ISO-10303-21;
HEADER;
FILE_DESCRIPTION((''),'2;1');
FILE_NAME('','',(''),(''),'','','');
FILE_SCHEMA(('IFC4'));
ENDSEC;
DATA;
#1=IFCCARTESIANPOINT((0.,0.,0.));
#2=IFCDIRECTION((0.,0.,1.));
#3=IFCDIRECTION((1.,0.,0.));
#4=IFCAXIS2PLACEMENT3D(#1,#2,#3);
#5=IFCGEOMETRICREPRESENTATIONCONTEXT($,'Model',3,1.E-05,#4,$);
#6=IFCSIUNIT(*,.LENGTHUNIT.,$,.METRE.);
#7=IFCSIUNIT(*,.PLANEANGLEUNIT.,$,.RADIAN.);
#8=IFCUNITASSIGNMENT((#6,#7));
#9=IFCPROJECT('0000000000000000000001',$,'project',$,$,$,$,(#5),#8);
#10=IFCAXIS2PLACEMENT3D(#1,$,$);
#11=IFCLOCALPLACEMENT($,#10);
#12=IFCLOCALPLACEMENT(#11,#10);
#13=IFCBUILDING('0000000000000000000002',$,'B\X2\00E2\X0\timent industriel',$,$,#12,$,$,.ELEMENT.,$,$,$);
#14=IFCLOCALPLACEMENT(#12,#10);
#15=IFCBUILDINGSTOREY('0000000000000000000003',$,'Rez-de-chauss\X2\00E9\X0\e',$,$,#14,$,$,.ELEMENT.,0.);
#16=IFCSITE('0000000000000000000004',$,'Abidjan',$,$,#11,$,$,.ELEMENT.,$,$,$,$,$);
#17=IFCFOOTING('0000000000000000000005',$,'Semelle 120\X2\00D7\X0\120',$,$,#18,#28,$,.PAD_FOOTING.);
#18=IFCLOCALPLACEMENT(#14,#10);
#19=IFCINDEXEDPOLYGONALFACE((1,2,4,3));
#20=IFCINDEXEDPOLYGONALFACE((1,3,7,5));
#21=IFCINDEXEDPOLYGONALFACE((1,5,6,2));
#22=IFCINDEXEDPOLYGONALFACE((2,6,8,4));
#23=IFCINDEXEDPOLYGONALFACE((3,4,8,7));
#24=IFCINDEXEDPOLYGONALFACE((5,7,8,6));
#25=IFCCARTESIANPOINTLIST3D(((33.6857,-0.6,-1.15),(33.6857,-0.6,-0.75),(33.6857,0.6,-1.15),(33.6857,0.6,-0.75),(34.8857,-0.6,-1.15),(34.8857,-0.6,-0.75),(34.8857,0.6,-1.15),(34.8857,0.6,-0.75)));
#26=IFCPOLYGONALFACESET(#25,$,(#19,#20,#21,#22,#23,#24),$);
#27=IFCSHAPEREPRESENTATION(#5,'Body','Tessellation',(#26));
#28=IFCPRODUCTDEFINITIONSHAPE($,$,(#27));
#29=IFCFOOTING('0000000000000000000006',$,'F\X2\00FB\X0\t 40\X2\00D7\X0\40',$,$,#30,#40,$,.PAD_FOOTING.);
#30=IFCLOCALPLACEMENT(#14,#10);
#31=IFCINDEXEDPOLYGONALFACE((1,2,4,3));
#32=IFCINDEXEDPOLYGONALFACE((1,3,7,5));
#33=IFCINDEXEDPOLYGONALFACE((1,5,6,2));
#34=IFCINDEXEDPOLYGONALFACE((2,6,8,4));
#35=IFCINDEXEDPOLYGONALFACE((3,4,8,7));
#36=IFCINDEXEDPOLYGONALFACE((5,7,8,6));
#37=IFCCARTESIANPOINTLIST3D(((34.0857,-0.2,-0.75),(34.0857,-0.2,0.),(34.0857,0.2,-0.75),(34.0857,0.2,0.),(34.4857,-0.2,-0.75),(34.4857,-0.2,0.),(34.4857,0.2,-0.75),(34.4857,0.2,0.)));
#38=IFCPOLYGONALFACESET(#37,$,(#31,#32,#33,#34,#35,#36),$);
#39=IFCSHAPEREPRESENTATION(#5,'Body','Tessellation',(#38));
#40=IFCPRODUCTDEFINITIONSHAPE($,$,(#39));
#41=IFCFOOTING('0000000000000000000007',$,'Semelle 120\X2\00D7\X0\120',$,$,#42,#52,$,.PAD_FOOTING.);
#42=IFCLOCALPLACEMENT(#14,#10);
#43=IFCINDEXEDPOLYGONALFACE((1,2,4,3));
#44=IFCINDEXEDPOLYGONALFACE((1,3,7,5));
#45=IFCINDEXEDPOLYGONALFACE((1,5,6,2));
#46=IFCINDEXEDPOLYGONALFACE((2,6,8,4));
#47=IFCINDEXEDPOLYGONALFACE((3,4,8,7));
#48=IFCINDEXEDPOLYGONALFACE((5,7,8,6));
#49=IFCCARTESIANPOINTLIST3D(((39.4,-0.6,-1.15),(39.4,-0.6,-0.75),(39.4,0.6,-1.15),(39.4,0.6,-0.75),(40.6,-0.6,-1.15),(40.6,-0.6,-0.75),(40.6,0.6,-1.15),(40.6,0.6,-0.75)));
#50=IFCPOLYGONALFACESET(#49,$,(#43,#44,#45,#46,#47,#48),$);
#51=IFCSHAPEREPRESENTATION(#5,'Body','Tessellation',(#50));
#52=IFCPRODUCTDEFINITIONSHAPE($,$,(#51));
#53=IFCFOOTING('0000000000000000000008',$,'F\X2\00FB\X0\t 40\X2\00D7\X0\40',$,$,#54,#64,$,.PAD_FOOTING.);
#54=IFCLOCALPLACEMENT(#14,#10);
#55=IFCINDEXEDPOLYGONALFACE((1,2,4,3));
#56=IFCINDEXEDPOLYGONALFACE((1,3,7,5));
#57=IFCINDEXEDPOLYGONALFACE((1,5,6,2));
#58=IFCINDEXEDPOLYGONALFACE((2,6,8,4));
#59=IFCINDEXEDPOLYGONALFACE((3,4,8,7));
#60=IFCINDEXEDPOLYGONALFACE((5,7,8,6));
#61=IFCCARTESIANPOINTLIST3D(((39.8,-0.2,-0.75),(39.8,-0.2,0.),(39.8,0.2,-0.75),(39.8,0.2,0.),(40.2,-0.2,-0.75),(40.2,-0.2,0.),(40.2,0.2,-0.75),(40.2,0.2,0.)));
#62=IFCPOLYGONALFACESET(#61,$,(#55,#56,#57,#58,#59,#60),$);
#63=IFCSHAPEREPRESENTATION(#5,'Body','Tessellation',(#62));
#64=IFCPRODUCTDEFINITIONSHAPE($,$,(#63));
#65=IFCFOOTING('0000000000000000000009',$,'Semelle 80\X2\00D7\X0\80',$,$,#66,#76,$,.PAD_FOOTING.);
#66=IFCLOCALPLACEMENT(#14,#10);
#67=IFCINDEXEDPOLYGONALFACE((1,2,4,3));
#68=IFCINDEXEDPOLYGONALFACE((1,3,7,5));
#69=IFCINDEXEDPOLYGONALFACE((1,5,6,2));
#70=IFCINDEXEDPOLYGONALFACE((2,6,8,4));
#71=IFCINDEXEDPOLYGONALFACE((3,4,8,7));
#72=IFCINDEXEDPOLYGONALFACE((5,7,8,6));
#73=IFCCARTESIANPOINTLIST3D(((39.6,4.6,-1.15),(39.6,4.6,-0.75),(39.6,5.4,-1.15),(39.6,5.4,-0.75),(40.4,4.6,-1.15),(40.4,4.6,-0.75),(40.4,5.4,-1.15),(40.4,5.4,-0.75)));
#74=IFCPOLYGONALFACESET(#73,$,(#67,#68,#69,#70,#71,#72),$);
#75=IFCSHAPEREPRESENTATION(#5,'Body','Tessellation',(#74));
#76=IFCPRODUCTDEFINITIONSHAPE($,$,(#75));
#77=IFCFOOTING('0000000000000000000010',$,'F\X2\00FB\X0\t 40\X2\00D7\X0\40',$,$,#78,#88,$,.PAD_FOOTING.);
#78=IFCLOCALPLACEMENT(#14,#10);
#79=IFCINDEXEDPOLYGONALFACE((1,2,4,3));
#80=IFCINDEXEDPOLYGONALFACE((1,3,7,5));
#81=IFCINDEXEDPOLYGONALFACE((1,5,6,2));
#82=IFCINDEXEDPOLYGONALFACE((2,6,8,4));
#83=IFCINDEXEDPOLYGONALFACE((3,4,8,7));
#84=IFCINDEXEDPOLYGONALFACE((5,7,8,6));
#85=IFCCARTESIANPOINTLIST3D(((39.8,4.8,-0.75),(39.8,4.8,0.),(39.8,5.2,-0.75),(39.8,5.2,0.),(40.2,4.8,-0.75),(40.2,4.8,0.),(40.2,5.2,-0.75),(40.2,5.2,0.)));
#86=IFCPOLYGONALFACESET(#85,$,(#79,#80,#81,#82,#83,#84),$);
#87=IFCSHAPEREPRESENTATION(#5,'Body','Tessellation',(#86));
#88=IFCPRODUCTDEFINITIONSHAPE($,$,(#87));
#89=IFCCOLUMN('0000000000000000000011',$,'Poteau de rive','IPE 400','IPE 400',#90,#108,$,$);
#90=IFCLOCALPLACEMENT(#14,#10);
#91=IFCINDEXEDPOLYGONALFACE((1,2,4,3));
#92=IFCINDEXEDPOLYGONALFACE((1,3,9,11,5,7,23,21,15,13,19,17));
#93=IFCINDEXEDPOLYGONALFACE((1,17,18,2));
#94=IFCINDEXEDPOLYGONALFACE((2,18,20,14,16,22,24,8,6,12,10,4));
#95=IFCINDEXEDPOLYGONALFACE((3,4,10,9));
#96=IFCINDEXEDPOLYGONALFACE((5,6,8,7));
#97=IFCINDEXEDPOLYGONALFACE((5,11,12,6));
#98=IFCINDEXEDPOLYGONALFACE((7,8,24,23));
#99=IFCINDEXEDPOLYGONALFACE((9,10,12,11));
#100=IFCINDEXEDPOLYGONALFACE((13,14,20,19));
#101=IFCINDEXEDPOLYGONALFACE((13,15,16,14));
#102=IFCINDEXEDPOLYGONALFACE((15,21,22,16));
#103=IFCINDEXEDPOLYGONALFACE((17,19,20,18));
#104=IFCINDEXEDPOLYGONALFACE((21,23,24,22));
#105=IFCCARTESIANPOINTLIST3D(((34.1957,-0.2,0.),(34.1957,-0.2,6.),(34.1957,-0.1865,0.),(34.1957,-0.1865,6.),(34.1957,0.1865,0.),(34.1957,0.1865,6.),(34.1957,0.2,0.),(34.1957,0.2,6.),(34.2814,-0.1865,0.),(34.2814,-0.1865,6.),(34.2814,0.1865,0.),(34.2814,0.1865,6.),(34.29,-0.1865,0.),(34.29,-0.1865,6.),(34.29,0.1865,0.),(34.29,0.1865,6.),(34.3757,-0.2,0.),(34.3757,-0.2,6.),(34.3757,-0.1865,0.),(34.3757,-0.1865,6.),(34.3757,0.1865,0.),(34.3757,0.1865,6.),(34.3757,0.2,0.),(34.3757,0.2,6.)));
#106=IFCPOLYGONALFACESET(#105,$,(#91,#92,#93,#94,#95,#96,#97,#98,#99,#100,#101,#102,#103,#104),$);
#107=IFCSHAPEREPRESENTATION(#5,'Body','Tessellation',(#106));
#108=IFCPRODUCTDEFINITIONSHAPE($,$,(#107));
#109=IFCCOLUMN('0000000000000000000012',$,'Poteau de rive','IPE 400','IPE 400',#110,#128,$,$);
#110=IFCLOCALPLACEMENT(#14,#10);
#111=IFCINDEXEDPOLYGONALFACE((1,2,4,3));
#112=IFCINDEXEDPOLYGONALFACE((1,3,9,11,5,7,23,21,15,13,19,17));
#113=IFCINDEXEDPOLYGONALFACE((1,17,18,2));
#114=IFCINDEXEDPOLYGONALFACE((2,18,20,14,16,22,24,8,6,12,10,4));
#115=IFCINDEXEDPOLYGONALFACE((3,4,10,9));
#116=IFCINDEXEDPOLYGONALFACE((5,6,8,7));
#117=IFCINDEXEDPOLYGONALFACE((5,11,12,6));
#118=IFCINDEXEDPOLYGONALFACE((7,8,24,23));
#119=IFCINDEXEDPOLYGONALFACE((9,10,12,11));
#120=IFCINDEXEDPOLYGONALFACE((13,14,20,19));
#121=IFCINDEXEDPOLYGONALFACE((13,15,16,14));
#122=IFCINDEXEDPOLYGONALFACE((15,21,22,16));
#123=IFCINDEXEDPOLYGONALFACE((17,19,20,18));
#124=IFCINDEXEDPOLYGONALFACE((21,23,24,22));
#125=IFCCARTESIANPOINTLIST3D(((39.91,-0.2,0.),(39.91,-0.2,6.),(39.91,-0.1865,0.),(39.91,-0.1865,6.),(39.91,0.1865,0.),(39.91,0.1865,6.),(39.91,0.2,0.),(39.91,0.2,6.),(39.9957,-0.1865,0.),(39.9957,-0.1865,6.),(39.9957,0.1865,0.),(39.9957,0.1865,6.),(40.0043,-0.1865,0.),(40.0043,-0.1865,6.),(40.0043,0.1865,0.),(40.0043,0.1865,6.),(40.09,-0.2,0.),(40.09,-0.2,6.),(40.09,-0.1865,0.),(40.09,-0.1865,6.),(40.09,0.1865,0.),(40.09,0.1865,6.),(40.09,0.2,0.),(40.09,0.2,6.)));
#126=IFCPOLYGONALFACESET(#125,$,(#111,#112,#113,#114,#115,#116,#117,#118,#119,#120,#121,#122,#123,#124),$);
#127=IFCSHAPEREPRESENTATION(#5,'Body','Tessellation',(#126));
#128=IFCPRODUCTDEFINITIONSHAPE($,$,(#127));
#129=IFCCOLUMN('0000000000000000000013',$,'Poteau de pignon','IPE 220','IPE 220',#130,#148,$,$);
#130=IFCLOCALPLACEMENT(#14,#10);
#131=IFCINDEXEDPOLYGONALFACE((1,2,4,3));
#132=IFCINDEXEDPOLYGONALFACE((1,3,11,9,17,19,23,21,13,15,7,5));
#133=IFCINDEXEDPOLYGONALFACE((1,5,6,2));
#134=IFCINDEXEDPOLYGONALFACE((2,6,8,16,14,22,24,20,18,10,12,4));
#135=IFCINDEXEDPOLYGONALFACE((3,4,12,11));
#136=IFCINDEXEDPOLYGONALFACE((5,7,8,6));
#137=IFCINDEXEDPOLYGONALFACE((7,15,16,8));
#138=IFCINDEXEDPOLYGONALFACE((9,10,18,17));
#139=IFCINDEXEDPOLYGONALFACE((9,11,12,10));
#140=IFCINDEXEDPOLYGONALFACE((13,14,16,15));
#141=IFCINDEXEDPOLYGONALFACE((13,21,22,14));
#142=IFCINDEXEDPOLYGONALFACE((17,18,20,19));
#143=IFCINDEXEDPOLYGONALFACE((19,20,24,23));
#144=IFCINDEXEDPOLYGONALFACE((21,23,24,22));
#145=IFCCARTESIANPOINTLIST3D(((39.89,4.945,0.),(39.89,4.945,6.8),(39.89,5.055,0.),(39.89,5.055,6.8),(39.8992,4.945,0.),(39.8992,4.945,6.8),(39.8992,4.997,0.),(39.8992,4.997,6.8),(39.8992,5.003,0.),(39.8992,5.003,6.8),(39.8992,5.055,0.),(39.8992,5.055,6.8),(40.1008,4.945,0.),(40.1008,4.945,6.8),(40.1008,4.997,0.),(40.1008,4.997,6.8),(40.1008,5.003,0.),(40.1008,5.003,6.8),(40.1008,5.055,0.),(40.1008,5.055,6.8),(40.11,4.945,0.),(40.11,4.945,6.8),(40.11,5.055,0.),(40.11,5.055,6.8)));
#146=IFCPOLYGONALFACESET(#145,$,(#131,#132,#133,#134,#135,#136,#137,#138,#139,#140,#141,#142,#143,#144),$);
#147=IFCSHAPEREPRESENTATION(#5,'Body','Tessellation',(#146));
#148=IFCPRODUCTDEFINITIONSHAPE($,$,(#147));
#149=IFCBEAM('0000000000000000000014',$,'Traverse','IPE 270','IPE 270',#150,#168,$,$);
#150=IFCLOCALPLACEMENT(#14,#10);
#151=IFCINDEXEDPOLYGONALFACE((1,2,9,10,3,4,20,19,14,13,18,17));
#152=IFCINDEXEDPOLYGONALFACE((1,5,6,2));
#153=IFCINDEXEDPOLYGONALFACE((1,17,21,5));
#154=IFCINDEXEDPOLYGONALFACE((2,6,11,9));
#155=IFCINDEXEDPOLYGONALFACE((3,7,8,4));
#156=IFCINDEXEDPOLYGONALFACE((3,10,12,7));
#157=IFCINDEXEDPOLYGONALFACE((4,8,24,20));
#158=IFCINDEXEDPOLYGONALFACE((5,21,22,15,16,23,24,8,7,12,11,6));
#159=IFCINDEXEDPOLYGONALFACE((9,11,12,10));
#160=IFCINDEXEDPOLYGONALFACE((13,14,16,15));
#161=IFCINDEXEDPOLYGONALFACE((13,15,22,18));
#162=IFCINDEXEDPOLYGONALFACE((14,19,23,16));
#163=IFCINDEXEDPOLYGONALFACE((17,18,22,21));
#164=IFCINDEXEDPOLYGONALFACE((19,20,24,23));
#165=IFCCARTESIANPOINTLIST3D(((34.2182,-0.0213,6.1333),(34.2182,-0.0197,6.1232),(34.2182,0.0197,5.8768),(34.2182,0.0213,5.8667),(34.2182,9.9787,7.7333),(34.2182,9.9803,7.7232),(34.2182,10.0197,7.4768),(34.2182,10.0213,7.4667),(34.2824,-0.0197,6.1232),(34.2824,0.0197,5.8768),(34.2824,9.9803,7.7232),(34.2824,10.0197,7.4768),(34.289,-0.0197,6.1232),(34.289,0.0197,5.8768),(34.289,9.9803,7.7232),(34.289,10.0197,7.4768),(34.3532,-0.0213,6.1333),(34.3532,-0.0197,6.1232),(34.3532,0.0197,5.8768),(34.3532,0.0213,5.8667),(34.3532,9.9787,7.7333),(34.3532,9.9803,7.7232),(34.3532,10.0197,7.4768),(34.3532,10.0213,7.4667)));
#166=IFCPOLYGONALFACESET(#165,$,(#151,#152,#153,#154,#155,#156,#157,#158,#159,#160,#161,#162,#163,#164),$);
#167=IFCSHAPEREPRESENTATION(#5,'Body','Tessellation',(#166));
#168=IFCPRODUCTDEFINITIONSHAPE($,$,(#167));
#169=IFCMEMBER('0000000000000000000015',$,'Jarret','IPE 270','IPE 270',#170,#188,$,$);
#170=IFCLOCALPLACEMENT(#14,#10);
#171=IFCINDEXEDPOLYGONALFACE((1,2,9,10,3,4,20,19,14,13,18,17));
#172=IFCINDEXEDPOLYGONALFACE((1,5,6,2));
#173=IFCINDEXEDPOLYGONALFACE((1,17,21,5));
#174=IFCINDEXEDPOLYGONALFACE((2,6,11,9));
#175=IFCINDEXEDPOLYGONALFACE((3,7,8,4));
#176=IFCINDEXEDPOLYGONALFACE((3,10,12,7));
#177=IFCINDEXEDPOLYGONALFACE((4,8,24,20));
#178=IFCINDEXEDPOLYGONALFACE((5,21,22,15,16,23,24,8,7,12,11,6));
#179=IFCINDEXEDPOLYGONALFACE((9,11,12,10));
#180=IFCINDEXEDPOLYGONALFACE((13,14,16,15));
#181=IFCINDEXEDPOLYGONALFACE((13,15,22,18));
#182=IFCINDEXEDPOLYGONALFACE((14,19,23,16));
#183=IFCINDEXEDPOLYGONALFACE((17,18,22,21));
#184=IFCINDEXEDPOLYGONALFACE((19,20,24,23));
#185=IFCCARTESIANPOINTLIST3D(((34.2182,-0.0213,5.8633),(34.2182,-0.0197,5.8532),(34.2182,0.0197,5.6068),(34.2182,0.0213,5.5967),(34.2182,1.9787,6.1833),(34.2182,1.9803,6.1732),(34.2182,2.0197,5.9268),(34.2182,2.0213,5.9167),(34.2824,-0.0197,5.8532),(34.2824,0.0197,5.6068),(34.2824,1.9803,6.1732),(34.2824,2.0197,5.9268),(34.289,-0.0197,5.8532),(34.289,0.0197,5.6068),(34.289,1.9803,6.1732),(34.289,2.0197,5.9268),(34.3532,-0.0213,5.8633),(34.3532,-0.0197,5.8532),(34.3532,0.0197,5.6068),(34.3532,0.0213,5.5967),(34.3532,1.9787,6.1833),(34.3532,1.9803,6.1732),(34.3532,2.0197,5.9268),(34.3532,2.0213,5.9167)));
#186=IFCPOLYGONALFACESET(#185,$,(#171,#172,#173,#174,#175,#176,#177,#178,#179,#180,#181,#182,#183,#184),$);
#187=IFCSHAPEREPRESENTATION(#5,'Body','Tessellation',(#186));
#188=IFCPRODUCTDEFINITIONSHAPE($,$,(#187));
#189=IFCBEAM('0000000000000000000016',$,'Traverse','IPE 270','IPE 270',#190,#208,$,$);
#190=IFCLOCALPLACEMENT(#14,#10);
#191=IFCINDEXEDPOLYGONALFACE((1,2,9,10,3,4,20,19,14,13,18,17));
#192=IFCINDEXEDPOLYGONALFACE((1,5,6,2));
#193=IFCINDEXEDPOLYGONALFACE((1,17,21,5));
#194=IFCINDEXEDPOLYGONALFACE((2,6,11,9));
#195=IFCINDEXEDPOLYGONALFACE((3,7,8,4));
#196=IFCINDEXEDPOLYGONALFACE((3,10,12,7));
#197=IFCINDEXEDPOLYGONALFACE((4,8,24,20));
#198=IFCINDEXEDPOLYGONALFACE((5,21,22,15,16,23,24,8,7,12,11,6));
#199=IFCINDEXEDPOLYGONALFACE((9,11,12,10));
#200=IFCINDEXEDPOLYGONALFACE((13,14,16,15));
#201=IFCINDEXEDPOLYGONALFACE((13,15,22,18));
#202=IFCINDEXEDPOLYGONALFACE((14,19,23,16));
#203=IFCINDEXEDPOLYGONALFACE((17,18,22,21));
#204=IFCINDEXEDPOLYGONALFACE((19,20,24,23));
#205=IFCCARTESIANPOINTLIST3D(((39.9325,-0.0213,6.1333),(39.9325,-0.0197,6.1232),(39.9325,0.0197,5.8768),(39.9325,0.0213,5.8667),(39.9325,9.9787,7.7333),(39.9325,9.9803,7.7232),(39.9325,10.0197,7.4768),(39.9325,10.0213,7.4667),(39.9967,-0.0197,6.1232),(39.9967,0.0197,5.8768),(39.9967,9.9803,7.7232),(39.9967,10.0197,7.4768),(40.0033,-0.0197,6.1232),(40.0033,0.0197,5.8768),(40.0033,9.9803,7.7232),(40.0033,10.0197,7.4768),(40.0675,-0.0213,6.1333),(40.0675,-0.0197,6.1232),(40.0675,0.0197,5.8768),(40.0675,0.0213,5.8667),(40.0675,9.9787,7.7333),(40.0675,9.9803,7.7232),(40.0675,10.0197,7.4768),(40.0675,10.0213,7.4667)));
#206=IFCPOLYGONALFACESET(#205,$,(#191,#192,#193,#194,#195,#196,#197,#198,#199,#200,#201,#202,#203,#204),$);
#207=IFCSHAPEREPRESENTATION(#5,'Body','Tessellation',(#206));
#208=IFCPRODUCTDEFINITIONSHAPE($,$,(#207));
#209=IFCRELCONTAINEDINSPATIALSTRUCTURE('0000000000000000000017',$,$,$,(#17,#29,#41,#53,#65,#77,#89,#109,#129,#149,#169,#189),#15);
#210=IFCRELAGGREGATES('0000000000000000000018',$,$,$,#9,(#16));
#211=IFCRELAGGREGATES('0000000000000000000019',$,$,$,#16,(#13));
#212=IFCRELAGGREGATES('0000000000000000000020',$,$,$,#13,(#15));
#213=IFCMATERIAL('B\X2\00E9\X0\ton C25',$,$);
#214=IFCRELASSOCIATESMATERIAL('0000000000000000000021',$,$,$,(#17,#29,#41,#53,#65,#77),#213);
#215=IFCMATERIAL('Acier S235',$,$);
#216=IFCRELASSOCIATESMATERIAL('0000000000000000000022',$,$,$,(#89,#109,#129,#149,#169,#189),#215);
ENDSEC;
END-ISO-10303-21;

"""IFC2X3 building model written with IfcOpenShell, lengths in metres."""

from ifc_helpers import new_model, si_unit, frame, origin, origin_with_axes, origin_2d, place, context, project, spatial, rectangle, i_section, extrude, material, element, save


model = new_model("IFC2X3")

# Units and contexts
model_context = context("Model", 3, precision=1e-05, world=origin_with_axes())
ifc_project = project(units=[si_unit("LENGTHUNIT", "METRE"), si_unit("PLANEANGLEUNIT", "RADIAN")], contexts=[model_context])

# Site, building, storey
site_placement = place(None, origin())
site = spatial("IfcSite", under=ifc_project, at=site_placement, Name="Abidjan", CompositionType="ELEMENT")
building_placement = place(site_placement, origin())
building = spatial("IfcBuilding", under=site, at=building_placement, Name="Bâtiment industriel", CompositionType="ELEMENT")
storey_placement = place(building_placement, origin())
storey = spatial("IfcBuildingStorey", under=building, at=storey_placement, Name="Rez-de-chaussée", CompositionType="ELEMENT", Elevation=0.0)

# Footings
ifc_material_1 = material(Name="Béton C25")
footing_1_placement = place(storey_placement, frame((34.2857, 0.0, -1.15), z_axis=(0.0, 0.0, 1.0), x_axis=(1.0, 0.0, 0.0)))
element("IfcFooting", 1, at=footing_1_placement, inside=storey, material=ifc_material_1, Name="Semelle 120×120", PredefinedType="PAD_FOOTING", context=model_context, shape_type="SweptSolid", body=[
    extrude(rectangle(XDim=1.2, YDim=1.2, at=origin_2d()), origin(), (0.0, 0.0, 1.0), 0.4),
])
footing_2_placement = place(storey_placement, frame((34.2857, 0.0, -0.75), z_axis=(0.0, 0.0, 1.0), x_axis=(1.0, 0.0, 0.0)))
element("IfcFooting", 2, at=footing_2_placement, inside=storey, material=ifc_material_1, Name="Fût 40×40", PredefinedType="PAD_FOOTING", context=model_context, shape_type="SweptSolid", body=[
    extrude(rectangle(XDim=0.4, YDim=0.4, at=origin_2d()), origin(), (0.0, 0.0, 1.0), 0.75),
])
footing_3_placement = place(storey_placement, frame((40.0, 0.0, -1.15), z_axis=(0.0, 0.0, 1.0), x_axis=(1.0, 0.0, 0.0)))
element("IfcFooting", 3, at=footing_3_placement, inside=storey, material=ifc_material_1, Name="Semelle 120×120", PredefinedType="PAD_FOOTING", context=model_context, shape_type="SweptSolid", body=[
    extrude(rectangle(XDim=1.2, YDim=1.2, at=origin_2d()), origin(), (0.0, 0.0, 1.0), 0.4),
])
footing_4_placement = place(storey_placement, frame((40.0, 0.0, -0.75), z_axis=(0.0, 0.0, 1.0), x_axis=(1.0, 0.0, 0.0)))
element("IfcFooting", 4, at=footing_4_placement, inside=storey, material=ifc_material_1, Name="Fût 40×40", PredefinedType="PAD_FOOTING", context=model_context, shape_type="SweptSolid", body=[
    extrude(rectangle(XDim=0.4, YDim=0.4, at=origin_2d()), origin(), (0.0, 0.0, 1.0), 0.75),
])
footing_5_placement = place(storey_placement, frame((40.0, 5.0, -1.15), z_axis=(0.0, 0.0, 1.0), x_axis=(1.0, 0.0, 0.0)))
element("IfcFooting", 5, at=footing_5_placement, inside=storey, material=ifc_material_1, Name="Semelle 80×80", PredefinedType="PAD_FOOTING", context=model_context, shape_type="SweptSolid", body=[
    extrude(rectangle(XDim=0.8, YDim=0.8, at=origin_2d()), origin(), (0.0, 0.0, 1.0), 0.4),
])
footing_6_placement = place(storey_placement, frame((40.0, 5.0, -0.75), z_axis=(0.0, 0.0, 1.0), x_axis=(1.0, 0.0, 0.0)))
element("IfcFooting", 6, at=footing_6_placement, inside=storey, material=ifc_material_1, Name="Fût 40×40", PredefinedType="PAD_FOOTING", context=model_context, shape_type="SweptSolid", body=[
    extrude(rectangle(XDim=0.4, YDim=0.4, at=origin_2d()), origin(), (0.0, 0.0, 1.0), 0.75),
])

# Columns
ifc_material_2 = material(Name="Acier S235")
for number, where, z_axis, x_axis, name in (
    (7, (34.2857, 0.0, 0.0), (0.0, 0.0, 1.0), (1.0, 0.0, 0.0), "Poteau de rive"),
    (8, (40.0, 0.0, 0.0), (0.0, 0.0, 1.0), (1.0, 0.0, 0.0), "Poteau de rive"),
):
    element("IfcColumn", number, at=place(storey_placement, frame(where, z_axis=z_axis, x_axis=x_axis)), inside=storey, material=ifc_material_2, Name=name, Description="IPE 400", ObjectType="IPE 400", context=model_context, shape_type="SweptSolid", body=[
        extrude(i_section(OverallWidth=0.18, OverallDepth=0.4, WebThickness=0.0086, FlangeThickness=0.0135, at=origin_2d()), origin(), (0.0, 0.0, 1.0), 6.0),
    ])
column_placement = place(storey_placement, frame((40.0, 5.0, 0.0), z_axis=(0.0, 0.0, 1.0), x_axis=(0.0, 1.0, 0.0)))
element("IfcColumn", 9, at=column_placement, inside=storey, material=ifc_material_2, Name="Poteau de pignon", Description="IPE 220", ObjectType="IPE 220", context=model_context, shape_type="SweptSolid", body=[
    extrude(i_section(OverallWidth=0.11, OverallDepth=0.22, WebThickness=0.0059, FlangeThickness=0.0092, at=origin_2d()), origin(), (0.0, 0.0, 1.0), 6.8),
])

# Beam
beam_1_placement = place(storey_placement, frame((34.2857, 0.0, 6.0), z_axis=(0.0, 0.98744, 0.15799), x_axis=(1.0, 0.0, 0.0)))
element("IfcBeam", 10, at=beam_1_placement, inside=storey, material=ifc_material_2, Name="Traverse", Description="IPE 270", ObjectType="IPE 270", context=model_context, shape_type="SweptSolid", body=[
    extrude(i_section(OverallWidth=0.135, OverallDepth=0.27, WebThickness=0.0066, FlangeThickness=0.0102, at=origin_2d()), origin(), (0.0, 0.0, 1.0), 10.1272),
])

# Member
member_1_placement = place(storey_placement, frame((34.2857, 0.0, 5.73), z_axis=(0.0, 0.98744, 0.15799), x_axis=(1.0, 0.0, 0.0)))
element("IfcMember", 11, at=member_1_placement, inside=storey, material=ifc_material_2, Name="Jarret", Description="IPE 270", ObjectType="IPE 270", context=model_context, shape_type="SweptSolid", body=[
    extrude(i_section(OverallWidth=0.135, OverallDepth=0.27, WebThickness=0.0066, FlangeThickness=0.0102, at=origin_2d()), origin(), (0.0, 0.0, 1.0), 2.0254),
])

# Beam
beam_2_placement = place(storey_placement, frame((40.0, 0.0, 6.0), z_axis=(0.0, 0.98744, 0.15799), x_axis=(1.0, 0.0, 0.0)))
element("IfcBeam", 12, at=beam_2_placement, inside=storey, material=ifc_material_2, Name="Traverse", Description="IPE 270", ObjectType="IPE 270", context=model_context, shape_type="SweptSolid", body=[
    extrude(i_section(OverallWidth=0.135, OverallDepth=0.27, WebThickness=0.0066, FlangeThickness=0.0102, at=origin_2d()), origin(), (0.0, 0.0, 1.0), 10.1272),
])

save(model, "model.ifc")
